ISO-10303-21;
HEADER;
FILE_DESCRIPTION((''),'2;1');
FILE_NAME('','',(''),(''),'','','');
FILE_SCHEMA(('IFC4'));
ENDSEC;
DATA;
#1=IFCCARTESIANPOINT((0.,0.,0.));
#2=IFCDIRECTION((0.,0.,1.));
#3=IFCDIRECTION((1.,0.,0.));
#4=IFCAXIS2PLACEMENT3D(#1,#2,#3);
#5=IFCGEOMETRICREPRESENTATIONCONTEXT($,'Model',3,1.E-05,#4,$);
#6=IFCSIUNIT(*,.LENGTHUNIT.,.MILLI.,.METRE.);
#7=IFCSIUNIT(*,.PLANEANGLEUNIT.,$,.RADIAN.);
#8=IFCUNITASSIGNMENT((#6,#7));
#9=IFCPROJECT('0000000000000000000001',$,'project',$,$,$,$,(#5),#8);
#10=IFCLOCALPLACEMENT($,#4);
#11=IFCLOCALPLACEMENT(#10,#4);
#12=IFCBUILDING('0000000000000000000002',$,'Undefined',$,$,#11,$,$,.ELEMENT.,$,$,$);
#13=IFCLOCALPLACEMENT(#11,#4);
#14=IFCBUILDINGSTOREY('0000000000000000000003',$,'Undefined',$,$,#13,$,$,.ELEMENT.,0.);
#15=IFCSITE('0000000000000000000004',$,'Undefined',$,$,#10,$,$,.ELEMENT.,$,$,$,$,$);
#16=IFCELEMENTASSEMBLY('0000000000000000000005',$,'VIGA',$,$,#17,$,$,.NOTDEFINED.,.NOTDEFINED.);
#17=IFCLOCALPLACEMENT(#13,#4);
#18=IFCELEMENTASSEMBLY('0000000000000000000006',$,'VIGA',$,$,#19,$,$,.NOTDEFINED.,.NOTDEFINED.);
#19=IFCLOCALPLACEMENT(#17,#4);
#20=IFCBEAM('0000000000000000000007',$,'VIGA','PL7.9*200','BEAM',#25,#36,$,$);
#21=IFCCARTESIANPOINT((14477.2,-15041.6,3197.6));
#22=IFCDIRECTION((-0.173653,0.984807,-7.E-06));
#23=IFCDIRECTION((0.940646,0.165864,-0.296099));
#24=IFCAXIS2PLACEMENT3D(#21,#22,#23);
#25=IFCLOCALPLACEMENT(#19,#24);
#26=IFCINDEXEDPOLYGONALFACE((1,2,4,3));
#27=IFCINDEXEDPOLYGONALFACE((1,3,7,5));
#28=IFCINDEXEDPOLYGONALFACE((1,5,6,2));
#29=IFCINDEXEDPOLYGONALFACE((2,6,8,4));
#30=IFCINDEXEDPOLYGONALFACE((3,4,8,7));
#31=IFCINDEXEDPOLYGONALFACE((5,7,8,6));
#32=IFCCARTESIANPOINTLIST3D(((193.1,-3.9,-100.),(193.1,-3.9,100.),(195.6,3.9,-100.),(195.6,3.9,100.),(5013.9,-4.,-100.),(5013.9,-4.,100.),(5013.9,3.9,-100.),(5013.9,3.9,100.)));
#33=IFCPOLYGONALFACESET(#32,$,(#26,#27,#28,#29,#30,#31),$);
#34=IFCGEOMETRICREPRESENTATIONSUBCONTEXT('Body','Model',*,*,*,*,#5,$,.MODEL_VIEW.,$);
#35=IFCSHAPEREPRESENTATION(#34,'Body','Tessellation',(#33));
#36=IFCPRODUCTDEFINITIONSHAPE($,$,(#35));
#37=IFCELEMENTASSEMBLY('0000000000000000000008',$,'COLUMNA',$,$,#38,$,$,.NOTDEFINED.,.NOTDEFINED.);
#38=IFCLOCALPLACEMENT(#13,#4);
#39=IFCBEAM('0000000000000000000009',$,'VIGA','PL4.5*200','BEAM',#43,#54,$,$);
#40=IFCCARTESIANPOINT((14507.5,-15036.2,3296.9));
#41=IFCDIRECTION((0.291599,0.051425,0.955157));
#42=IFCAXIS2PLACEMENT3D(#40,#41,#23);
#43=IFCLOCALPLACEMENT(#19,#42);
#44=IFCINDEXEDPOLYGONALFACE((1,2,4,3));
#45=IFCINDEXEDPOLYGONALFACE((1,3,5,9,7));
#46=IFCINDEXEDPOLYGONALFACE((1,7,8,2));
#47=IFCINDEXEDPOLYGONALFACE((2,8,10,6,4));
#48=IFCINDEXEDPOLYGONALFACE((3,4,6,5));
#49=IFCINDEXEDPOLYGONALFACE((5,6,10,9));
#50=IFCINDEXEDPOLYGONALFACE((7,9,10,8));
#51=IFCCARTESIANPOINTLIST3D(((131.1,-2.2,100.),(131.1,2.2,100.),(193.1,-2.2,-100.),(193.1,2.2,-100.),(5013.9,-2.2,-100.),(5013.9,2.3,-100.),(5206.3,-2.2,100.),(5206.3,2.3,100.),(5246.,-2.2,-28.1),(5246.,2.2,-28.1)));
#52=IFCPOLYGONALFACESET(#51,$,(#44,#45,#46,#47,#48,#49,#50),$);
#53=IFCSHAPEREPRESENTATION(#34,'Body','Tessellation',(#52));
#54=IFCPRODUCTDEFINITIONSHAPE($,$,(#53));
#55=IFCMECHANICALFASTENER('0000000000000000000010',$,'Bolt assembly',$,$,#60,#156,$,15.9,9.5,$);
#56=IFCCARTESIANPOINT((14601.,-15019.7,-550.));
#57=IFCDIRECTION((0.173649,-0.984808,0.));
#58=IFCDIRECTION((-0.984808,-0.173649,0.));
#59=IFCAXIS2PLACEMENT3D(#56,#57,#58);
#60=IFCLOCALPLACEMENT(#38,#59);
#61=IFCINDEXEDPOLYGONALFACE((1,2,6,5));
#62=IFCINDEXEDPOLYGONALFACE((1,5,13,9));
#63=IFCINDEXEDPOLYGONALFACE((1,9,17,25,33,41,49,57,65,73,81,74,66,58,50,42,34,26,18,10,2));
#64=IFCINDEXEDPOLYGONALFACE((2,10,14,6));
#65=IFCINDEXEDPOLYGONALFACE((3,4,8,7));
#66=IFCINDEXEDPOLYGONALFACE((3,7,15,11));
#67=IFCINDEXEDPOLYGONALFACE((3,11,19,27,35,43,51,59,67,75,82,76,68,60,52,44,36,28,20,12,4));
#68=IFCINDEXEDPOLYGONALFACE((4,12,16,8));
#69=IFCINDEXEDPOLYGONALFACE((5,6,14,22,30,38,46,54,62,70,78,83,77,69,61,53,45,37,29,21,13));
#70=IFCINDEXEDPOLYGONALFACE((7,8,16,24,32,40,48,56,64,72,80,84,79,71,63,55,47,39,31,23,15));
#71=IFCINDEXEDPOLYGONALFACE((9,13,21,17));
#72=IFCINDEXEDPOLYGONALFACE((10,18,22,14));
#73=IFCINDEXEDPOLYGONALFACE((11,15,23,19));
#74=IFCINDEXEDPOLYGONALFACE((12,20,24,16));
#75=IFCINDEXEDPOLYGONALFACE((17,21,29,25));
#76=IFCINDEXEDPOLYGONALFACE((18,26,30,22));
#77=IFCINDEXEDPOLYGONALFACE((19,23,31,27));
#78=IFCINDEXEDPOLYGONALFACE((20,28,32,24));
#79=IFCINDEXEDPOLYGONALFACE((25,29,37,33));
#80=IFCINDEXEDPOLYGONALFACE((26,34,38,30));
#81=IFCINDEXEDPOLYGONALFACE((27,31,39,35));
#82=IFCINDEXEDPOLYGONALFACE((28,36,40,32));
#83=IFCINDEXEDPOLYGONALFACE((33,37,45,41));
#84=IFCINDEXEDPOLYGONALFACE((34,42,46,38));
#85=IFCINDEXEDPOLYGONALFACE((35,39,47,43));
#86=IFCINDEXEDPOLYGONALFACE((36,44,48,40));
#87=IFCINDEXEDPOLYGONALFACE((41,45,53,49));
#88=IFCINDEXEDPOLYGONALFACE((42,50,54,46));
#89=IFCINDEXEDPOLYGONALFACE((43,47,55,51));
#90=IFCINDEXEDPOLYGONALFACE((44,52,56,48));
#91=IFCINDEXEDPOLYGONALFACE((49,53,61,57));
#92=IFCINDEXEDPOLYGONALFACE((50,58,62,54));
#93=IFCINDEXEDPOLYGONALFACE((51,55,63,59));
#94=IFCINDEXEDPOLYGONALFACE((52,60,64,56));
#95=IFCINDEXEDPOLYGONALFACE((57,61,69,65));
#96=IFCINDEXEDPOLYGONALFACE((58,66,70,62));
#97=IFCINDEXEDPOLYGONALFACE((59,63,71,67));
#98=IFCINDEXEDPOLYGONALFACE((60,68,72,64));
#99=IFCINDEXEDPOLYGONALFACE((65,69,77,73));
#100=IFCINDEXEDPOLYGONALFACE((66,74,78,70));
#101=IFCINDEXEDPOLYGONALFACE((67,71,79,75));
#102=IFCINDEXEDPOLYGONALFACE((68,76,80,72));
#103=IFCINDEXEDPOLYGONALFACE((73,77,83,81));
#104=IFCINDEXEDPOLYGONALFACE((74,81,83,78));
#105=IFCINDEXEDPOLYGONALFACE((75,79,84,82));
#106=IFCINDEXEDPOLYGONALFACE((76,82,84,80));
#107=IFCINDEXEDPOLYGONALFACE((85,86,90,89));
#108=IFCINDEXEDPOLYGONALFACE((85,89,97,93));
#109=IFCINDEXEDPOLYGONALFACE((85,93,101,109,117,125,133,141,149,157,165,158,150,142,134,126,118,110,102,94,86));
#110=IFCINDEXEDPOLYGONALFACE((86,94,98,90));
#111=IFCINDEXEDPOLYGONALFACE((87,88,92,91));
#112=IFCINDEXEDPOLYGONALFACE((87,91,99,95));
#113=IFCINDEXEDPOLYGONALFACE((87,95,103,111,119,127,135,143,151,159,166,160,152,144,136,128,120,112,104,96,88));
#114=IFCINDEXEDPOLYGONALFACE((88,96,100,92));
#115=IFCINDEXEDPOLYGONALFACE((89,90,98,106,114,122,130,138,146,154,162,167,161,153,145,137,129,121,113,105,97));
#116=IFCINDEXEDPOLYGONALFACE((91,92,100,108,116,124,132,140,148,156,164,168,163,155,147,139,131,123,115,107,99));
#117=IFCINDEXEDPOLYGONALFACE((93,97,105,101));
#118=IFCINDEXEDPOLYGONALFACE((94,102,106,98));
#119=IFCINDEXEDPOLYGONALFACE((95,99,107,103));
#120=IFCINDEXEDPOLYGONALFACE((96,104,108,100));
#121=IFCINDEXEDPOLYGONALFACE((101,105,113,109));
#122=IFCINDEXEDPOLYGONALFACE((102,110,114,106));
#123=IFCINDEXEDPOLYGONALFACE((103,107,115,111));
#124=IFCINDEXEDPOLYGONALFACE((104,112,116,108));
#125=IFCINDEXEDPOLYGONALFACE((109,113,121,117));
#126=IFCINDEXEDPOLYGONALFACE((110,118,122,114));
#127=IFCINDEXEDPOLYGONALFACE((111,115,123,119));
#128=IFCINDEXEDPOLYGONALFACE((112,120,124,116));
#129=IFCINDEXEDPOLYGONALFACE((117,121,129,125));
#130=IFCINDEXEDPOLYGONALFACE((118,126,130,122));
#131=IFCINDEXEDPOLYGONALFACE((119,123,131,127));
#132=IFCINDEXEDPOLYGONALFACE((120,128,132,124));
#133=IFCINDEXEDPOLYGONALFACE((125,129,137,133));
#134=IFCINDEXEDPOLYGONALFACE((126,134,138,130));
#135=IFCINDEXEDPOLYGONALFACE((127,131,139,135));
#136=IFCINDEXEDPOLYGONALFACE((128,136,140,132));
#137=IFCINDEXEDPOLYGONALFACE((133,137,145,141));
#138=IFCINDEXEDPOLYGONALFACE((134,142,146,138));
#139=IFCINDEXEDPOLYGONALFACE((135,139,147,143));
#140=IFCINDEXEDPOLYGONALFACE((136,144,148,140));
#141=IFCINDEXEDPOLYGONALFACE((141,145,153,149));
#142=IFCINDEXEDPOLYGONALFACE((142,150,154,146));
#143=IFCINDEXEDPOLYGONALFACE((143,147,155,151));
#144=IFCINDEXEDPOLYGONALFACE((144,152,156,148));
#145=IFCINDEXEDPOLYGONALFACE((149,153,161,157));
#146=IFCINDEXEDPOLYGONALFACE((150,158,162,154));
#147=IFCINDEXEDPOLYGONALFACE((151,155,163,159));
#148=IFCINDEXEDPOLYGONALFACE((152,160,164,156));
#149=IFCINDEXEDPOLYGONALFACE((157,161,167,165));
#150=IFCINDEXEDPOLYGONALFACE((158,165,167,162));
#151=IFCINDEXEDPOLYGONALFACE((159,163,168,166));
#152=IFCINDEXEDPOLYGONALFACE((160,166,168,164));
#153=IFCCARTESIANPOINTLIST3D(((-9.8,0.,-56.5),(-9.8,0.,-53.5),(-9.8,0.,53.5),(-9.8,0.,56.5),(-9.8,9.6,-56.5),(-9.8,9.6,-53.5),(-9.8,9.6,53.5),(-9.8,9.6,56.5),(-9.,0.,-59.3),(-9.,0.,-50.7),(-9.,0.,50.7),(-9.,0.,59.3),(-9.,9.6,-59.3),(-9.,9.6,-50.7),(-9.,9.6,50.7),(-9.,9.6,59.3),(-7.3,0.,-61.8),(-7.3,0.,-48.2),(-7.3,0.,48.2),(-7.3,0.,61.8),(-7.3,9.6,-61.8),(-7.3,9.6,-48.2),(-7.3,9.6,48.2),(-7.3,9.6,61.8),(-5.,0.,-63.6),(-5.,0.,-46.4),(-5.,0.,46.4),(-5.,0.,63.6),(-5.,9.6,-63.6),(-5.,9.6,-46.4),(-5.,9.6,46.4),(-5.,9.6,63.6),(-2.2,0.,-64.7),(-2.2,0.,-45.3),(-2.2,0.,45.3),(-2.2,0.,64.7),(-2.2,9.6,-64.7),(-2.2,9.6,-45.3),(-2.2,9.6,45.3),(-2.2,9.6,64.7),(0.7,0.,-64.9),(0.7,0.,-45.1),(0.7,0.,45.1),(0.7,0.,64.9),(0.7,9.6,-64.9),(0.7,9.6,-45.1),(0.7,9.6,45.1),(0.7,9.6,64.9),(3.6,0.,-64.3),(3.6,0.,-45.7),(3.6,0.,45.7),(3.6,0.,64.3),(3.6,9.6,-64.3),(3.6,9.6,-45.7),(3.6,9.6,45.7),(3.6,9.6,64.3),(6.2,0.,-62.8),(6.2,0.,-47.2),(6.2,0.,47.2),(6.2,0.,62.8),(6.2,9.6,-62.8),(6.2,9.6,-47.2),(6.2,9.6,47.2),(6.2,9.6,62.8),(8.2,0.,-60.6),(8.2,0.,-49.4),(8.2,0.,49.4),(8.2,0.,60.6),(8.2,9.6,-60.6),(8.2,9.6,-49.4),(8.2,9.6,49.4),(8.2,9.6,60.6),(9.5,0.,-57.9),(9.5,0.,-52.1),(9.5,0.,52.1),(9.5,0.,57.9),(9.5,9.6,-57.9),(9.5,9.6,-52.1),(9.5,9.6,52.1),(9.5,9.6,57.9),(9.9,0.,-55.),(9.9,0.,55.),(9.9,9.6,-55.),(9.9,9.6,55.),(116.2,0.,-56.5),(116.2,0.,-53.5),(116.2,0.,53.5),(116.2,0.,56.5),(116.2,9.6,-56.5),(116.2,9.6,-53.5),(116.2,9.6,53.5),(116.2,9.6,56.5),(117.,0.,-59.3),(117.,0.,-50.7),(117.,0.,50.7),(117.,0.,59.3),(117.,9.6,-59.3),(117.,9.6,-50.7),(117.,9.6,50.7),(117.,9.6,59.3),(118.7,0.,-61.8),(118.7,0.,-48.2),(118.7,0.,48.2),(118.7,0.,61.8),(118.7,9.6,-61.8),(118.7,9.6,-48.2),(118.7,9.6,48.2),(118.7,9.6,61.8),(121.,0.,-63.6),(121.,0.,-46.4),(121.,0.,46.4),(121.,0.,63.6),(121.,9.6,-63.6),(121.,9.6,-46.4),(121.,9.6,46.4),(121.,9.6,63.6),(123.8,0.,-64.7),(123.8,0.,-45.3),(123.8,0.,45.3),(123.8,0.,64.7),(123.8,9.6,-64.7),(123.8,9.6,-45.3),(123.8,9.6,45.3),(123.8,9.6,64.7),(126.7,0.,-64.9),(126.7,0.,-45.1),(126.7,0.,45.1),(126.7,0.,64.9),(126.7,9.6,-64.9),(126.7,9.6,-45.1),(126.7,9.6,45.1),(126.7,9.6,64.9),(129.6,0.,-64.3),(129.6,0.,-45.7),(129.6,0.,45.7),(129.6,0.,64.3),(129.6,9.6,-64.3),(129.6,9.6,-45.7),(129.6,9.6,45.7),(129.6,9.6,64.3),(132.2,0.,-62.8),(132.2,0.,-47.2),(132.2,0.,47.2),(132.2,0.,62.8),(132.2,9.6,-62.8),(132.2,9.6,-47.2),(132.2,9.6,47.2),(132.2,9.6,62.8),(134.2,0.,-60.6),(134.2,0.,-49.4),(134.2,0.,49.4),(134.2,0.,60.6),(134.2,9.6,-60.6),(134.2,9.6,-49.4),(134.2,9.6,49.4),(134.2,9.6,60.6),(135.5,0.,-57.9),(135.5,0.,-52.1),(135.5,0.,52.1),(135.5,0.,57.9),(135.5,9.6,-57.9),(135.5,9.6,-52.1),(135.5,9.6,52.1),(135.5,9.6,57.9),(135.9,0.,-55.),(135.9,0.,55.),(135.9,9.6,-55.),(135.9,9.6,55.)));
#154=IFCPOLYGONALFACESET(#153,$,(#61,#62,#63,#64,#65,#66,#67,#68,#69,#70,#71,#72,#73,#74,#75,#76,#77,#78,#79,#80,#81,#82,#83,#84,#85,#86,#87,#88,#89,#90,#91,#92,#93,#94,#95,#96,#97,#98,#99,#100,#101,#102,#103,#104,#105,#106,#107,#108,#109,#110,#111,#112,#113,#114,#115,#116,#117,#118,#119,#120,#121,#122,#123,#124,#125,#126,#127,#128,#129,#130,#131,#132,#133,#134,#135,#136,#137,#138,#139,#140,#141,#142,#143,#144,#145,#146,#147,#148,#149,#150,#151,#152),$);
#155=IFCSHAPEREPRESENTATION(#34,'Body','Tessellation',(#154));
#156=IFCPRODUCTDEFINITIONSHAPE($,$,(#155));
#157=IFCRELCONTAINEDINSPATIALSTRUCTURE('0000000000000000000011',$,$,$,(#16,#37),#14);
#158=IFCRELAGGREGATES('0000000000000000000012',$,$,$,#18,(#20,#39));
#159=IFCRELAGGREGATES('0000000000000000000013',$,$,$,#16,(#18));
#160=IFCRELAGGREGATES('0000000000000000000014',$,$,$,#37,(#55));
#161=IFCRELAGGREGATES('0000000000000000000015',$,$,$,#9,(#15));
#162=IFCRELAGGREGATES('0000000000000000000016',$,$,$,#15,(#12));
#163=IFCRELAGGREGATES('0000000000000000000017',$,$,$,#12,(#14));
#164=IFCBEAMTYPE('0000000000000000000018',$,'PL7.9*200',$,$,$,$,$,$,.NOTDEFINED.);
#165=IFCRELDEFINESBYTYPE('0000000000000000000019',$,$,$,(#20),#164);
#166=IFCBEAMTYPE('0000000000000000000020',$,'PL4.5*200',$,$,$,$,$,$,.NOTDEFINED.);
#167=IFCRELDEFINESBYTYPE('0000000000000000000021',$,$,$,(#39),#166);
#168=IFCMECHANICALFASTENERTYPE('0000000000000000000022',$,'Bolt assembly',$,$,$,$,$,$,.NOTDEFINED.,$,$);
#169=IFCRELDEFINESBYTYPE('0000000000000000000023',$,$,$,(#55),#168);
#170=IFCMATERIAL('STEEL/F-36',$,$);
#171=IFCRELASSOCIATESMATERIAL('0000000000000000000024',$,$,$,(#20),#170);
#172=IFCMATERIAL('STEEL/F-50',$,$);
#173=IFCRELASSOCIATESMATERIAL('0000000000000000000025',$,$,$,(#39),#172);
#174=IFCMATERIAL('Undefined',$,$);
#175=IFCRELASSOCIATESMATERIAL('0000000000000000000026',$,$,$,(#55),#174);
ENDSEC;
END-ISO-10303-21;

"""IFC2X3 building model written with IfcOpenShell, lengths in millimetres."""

from ifc_helpers import new_model, si_unit, frame, origin_with_axes, origin_2d_with_axis, place, context, subcontext, project, spatial, polyline, rectangle, circle, outline, extrude, boolean, clip, halfspace, source, transform, mapped, material, type_object, element, aggregate, save


model = new_model("IFC2X3")

# Units and contexts
model_context = context("Model", 3, precision=1e-05, world=origin_with_axes())
body_context = subcontext(model_context, "Body", "Model", "MODEL_VIEW")
ifc_project = project(units=[si_unit("LENGTHUNIT", "METRE", prefix="MILLI"), si_unit("PLANEANGLEUNIT", "RADIAN")], contexts=[model_context])

# Site, building, storey
site_placement = place(None, origin_with_axes())
site = spatial("IfcSite", under=ifc_project, at=site_placement, Name="Undefined", CompositionType="ELEMENT")
building_placement = place(site_placement, origin_with_axes())
building = spatial("IfcBuilding", under=site, at=building_placement, Name="Undefined", CompositionType="ELEMENT")
storey_placement = place(building_placement, origin_with_axes())
storey = spatial("IfcBuildingStorey", under=building, at=storey_placement, Name="Undefined", CompositionType="ELEMENT", Elevation=0.0)

# Element assemblies, beam
assembly_1_placement = place(storey_placement, origin_with_axes())
assembly_1 = element("IfcElementAssembly", 1, at=assembly_1_placement, inside=storey, Name="VIGA", AssemblyPlace="NOTDEFINED", PredefinedType="NOTDEFINED")
assembly_2_placement = place(assembly_1_placement, origin_with_axes())
assembly_2 = element("IfcElementAssembly", 2, at=assembly_2_placement, Name="VIGA", AssemblyPlace="NOTDEFINED", PredefinedType="NOTDEFINED")
ifc_material_1 = material(Name="STEEL/F-36")
beam_type_1 = type_object("IfcBeamType", Name="PL7.9*200", PredefinedType="NOTDEFINED")
beam_1_placement = place(assembly_2_placement, frame((14477.2, -15041.6, 3197.6), z_axis=(-0.173653, 0.984807, -0.000007), x_axis=(0.940646, 0.165864, -0.296099)))
beam_1 = element("IfcBeam", 3, at=beam_1_placement, type_object=beam_type_1, material=ifc_material_1, Name="VIGA", Description="PL7.9*200", ObjectType="BEAM", context=body_context, shape_type="Clipping", body=[
    clip(extrude(rectangle(XDim=7.9, YDim=200.0, at=origin_2d_with_axis()), frame((5013.9, 0.0, 0.0), z_axis=(-1.0, 0.0, 0.0), x_axis=(0.0, -1.0, 0.0)), (0.0, 0.0, 1.0), 5013.9), halfspace(frame((194.3, 0.0, 0.0), z_axis=(0.955157, -0.296099, -0.000004), x_axis=(-0.000001, 0.000008, -1.0)), True)),
])

# Element assembly
assembly_3_placement = place(storey_placement, origin_with_axes())
assembly_3 = element("IfcElementAssembly", 4, at=assembly_3_placement, inside=storey, Name="COLUMNA", AssemblyPlace="NOTDEFINED", PredefinedType="NOTDEFINED")

# Beam
ifc_material_2 = material(Name="STEEL/F-50")
beam_type_2 = type_object("IfcBeamType", Name="PL4.5*200", PredefinedType="NOTDEFINED")
beam_2_placement = place(assembly_2_placement, frame((14507.5, -15036.2, 3296.9), z_axis=(0.291599, 0.051425, 0.955157), x_axis=(0.940646, 0.165864, -0.296099)))
beam_2 = element("IfcBeam", 5, at=beam_2_placement, type_object=beam_type_2, material=ifc_material_2, Name="VIGA", Description="PL4.5*200", ObjectType="BEAM", context=body_context, shape_type="CSG", body=[
    boolean("DIFFERENCE", boolean("DIFFERENCE", extrude(rectangle(XDim=4.5, YDim=200.0, at=origin_2d_with_axis()), frame((5284.7, 0.0, 0.0), z_axis=(-1.0, 0.0, 0.0), x_axis=(0.0, -1.0, 0.0)), (0.0, 0.0, 1.0), 5284.7), extrude(outline(polyline([(0.0, 0.0), (270.8, 0.0), (270.8, 200.0), (192.4, 200.0), (232.1, 71.9), (0.0, 0.0)])), frame((5013.9, 5.0, -100.0), z_axis=(-0.000001, -1.0, -0.000008), x_axis=(1.0, -0.000001, 0.0)), (0.0, 0.0, 1.0), 10.0)), halfspace(frame((162.1, 0.0, 0.0), z_axis=(0.955157, -0.000004, 0.296099), x_axis=(-0.000001, -1.0, -0.000008)), True)),
])
aggregate(assembly_2, [beam_1, beam_2])

# Mechanical fastener
ifc_material_3 = material(Name="Undefined")
mechanical_fastener_type = type_object("IfcMechanicalFastenerType", Name="Bolt assembly")
aggregate(assembly_1, [assembly_2])
shared_shape_1 = source(origin_with_axes(), body_context, "Body", "SweptSolid", [
    extrude(circle(Radius=9.9, at=origin_2d_with_axis()), frame((0.0, 0.0, 0.0), z_axis=(0.0, 1.0, 0.0), x_axis=(1.0, 0.0, 0.0)), (0.0, 0.0, 1.0), 9.6),
])
mechanical_fastener_1_placement = place(assembly_3_placement, frame((14601.0, -15019.7, -550.0), z_axis=(0.173649, -0.984808, 0.0), x_axis=(-0.984808, -0.173649, 0.0)))
mechanical_fastener_1 = element("IfcMechanicalFastener", 6, at=mechanical_fastener_1_placement, type_object=mechanical_fastener_type, material=ifc_material_3, Name="Bolt assembly", NominalDiameter=15.9, NominalLength=9.5, context=body_context, shape_type="MappedRepresentation", body=[
    mapped(shared_shape_1, transform((0.0, 0.0, -55.0))),
    mapped(shared_shape_1, transform((126.0, 0.0, -55.0))),
    mapped(shared_shape_1, transform((0.0, 0.0, 55.0))),
    mapped(shared_shape_1, transform((126.0, 0.0, 55.0))),
])
aggregate(assembly_3, [mechanical_fastener_1])

save(model, "model.ifc")
